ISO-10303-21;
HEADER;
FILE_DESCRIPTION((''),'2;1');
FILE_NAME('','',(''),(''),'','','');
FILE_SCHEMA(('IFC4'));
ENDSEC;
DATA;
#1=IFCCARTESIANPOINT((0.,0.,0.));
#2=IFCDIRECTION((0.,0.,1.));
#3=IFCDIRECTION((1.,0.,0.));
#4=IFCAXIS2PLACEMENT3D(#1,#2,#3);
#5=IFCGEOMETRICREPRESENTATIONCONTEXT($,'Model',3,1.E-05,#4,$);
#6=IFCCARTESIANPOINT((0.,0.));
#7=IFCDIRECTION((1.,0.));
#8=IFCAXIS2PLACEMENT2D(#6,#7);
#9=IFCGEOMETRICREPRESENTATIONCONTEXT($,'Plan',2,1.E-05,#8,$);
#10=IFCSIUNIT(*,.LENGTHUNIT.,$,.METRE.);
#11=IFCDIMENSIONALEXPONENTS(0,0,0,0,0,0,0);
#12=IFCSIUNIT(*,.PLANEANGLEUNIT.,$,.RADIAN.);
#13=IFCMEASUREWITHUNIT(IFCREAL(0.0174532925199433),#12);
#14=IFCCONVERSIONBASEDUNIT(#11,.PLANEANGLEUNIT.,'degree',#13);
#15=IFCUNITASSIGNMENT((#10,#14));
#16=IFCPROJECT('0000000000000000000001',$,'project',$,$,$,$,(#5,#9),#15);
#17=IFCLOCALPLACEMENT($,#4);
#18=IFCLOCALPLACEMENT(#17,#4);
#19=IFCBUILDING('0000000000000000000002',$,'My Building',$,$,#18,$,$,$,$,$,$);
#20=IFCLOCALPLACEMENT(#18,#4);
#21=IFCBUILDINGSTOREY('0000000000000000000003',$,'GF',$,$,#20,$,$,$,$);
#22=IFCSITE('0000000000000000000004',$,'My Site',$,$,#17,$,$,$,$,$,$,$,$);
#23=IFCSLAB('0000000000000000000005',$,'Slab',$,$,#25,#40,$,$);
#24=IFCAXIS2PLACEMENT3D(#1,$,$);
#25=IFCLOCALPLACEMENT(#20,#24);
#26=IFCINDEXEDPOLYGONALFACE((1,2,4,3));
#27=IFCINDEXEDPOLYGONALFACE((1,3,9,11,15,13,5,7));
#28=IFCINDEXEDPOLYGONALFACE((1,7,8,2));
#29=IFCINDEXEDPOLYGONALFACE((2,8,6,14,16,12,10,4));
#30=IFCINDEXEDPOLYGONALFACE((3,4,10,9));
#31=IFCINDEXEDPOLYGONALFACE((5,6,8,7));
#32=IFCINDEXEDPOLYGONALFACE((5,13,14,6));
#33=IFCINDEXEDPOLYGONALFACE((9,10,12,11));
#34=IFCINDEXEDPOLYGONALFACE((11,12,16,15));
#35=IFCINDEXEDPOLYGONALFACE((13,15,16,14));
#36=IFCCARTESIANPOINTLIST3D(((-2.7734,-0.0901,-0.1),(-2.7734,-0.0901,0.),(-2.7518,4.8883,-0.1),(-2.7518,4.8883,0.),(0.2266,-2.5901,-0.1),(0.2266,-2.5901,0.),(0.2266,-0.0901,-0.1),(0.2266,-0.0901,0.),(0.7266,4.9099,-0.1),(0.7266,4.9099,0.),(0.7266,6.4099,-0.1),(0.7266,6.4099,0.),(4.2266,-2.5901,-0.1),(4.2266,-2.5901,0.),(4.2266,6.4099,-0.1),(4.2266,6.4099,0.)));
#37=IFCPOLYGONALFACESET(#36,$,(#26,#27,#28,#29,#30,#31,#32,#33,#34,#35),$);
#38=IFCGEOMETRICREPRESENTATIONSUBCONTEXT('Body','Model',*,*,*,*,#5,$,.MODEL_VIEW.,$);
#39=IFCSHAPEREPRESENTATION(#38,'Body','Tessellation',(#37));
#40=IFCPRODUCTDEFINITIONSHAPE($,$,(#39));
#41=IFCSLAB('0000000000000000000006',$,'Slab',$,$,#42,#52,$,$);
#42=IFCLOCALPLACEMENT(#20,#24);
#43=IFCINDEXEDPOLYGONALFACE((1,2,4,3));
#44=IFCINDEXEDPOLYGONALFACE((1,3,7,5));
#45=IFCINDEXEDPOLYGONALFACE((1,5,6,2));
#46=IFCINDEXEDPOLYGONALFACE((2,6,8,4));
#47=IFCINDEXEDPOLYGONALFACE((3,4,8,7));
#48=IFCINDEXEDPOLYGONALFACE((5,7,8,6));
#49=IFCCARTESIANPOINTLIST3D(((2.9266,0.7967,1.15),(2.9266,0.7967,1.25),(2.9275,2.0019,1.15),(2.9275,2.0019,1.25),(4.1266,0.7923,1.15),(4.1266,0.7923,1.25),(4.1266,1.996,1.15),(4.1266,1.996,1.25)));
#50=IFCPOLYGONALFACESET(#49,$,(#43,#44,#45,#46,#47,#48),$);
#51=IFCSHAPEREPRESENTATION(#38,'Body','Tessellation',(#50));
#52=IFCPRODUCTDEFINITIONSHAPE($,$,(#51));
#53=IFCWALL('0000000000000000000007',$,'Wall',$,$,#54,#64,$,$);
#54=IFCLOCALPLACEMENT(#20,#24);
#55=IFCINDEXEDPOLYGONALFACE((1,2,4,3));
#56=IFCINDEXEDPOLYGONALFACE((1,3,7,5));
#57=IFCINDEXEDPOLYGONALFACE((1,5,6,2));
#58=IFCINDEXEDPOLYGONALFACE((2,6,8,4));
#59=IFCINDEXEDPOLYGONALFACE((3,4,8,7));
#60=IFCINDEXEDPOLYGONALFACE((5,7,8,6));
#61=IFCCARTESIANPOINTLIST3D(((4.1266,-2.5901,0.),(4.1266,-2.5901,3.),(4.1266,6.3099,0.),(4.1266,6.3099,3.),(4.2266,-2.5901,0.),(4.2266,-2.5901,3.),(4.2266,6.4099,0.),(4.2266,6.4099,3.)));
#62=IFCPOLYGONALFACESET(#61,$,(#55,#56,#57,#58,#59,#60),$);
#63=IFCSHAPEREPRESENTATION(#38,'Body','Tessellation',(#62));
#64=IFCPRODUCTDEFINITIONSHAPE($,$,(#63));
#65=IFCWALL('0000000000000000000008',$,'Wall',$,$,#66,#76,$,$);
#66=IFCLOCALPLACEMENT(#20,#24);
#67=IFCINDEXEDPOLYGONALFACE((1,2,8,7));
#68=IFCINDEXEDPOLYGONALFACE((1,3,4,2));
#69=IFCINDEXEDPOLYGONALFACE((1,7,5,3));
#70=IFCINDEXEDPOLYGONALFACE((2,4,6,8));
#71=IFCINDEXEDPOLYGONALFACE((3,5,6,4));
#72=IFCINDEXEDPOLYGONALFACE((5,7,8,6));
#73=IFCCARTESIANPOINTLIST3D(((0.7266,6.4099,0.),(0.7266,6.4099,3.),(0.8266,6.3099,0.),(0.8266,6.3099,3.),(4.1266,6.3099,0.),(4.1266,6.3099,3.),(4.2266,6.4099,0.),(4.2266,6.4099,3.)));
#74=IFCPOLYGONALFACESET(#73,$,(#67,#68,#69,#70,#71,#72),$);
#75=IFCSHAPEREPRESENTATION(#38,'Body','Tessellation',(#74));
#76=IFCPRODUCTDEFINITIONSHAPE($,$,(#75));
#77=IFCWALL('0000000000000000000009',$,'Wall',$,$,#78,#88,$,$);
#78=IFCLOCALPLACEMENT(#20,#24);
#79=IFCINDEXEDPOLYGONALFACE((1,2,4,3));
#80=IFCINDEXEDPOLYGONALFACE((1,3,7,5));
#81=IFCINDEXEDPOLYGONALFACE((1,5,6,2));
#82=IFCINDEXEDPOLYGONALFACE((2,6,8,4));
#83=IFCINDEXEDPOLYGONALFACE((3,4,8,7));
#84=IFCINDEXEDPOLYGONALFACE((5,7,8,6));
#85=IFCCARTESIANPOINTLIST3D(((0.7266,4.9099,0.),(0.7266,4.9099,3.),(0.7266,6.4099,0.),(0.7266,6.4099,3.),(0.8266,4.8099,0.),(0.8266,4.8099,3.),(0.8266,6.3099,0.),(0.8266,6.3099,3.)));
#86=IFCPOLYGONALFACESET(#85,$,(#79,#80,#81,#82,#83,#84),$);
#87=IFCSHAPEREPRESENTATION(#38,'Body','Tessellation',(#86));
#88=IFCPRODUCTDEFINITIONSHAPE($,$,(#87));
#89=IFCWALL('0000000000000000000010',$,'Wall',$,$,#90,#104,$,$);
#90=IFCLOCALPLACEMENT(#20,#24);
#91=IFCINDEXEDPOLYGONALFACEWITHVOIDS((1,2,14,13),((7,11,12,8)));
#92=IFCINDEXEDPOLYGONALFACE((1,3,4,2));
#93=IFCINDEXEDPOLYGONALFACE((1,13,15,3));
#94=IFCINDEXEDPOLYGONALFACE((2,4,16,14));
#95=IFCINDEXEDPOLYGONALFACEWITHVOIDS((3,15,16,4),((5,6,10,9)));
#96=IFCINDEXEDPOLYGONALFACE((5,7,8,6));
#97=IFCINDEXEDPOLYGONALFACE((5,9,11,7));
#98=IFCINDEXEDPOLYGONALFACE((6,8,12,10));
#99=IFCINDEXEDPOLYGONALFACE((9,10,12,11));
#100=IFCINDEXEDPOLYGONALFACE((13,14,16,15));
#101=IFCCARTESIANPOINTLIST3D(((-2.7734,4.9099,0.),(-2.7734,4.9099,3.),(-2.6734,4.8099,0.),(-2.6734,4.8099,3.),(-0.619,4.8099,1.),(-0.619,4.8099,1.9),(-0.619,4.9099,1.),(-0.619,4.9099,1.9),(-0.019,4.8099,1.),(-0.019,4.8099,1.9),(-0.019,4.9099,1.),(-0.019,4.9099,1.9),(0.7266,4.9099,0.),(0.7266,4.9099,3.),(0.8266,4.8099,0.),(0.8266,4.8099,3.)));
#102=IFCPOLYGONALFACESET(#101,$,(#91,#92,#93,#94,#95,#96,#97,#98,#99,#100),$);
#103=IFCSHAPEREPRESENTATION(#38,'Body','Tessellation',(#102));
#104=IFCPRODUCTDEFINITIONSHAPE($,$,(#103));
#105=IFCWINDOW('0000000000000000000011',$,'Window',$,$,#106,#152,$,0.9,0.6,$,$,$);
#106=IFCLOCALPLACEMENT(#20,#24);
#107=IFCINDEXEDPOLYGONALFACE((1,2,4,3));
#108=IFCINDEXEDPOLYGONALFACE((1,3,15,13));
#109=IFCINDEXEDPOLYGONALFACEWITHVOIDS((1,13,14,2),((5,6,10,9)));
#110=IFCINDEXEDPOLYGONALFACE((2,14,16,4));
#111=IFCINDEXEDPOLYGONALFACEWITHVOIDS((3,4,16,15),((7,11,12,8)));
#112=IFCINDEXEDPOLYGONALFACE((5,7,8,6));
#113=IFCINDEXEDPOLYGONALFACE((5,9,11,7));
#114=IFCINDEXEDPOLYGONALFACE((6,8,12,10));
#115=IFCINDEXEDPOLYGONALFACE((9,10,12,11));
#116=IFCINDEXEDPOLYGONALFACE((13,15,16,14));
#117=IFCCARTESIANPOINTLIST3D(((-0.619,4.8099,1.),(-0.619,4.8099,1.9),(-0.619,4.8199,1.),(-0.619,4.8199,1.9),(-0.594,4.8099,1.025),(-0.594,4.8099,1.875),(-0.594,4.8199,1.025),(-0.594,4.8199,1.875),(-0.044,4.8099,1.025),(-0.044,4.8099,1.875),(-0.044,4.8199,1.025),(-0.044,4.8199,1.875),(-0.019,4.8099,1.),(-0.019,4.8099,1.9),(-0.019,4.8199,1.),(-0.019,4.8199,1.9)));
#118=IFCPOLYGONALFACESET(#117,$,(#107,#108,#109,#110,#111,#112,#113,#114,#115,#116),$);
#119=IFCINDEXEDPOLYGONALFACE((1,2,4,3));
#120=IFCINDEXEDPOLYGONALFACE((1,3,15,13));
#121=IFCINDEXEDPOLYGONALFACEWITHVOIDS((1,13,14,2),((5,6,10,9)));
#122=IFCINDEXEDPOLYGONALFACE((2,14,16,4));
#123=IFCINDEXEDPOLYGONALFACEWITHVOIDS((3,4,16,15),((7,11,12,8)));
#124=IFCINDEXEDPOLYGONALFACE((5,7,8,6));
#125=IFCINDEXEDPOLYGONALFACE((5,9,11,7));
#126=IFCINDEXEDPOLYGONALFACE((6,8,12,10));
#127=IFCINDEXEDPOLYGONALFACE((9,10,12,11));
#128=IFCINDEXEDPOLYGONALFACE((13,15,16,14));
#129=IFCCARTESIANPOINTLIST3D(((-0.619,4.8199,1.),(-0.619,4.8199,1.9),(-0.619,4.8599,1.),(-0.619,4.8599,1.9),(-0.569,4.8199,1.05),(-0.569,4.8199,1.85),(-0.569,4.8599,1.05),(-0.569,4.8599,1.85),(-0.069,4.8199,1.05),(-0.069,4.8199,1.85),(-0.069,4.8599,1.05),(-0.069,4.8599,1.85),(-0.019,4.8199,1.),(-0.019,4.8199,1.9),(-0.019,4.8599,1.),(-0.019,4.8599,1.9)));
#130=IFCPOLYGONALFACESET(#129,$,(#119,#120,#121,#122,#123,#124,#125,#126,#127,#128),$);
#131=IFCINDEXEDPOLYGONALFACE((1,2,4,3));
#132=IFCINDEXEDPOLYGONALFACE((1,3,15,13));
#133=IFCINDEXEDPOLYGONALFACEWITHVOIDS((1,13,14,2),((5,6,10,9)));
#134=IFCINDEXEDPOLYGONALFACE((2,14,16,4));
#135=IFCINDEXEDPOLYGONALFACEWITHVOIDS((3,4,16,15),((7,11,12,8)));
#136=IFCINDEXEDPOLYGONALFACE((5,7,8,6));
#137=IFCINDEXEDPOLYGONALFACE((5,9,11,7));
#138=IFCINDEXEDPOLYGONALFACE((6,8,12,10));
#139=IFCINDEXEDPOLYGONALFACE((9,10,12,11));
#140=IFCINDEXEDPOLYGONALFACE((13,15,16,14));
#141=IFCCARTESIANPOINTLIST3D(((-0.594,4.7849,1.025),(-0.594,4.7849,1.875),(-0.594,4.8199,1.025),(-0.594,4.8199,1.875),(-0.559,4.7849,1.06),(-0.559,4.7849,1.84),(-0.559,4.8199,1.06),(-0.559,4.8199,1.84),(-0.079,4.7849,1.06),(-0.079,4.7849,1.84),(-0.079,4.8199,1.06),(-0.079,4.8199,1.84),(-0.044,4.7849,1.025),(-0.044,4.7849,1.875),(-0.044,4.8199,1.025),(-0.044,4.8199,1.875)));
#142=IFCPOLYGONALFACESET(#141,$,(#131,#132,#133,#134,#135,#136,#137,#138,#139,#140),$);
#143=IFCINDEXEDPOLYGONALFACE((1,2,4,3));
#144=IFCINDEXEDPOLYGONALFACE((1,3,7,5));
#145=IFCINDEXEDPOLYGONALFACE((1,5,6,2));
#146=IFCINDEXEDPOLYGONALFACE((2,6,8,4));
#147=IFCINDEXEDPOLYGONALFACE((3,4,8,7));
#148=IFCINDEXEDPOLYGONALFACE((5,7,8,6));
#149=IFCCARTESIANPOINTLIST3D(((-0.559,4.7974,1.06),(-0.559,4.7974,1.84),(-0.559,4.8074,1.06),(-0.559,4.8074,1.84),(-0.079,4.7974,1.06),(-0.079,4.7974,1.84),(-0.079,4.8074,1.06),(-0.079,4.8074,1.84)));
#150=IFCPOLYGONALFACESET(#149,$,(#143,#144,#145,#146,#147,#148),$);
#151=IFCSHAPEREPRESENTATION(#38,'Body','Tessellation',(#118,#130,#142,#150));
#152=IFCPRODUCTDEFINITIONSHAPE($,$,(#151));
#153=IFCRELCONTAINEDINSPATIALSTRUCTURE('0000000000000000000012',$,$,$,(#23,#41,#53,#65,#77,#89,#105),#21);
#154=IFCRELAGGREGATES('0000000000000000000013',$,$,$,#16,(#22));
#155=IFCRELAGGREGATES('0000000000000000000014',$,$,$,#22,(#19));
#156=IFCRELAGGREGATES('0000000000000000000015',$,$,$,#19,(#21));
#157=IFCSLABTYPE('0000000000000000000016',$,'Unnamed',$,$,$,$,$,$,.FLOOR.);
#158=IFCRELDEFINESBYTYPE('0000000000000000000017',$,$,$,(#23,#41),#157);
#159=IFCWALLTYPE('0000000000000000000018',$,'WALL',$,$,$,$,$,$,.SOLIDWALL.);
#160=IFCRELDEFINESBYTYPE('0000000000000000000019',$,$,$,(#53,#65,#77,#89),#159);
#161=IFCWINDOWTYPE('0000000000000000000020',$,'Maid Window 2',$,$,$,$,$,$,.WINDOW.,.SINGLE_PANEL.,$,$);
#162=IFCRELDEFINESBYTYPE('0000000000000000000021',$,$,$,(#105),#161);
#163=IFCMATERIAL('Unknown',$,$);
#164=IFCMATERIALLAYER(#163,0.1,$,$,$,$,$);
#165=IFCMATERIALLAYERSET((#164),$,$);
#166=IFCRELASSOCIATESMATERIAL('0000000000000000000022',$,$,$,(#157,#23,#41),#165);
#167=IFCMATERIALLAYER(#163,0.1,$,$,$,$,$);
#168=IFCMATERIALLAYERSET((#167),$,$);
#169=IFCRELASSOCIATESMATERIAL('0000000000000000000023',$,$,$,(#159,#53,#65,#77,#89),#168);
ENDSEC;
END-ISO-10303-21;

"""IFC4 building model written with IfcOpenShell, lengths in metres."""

from ifc_helpers import new_model, entity, si_unit, converted_unit, frame, origin_with_axes, origin_2d_with_axis, place, context, subcontext, project, spatial, line, indexed_curve, outline, extrude, shape, source, transform, mapped, material, layer, layer_set, layer_usage, type_object, type_shapes, element, fill, save


model = new_model("IFC4")

# Units and contexts
model_context = context("Model", 3, precision=1e-05, world=origin_with_axes())
plan_context = context("Plan", 2, precision=1e-05, world=origin_2d_with_axis())
body_context_1 = subcontext(model_context, "Body", "Model", "MODEL_VIEW")
body_context_2 = subcontext(plan_context, "Body", "Plan", "PLAN_VIEW")
ifc_project = project(units=[si_unit("LENGTHUNIT", "METRE"), converted_unit("PLANEANGLEUNIT", "degree", entity("IfcReal", 0.0174532925199433), si_unit("PLANEANGLEUNIT", "RADIAN"), dimensions=[0, 0, 0, 0, 0, 0, 0])], contexts=[model_context, plan_context])

# Site, building, storey
site_placement = place(None, origin_with_axes())
site = spatial("IfcSite", under=ifc_project, at=site_placement, Name="My Site")
building_placement = place(site_placement, origin_with_axes())
building = spatial("IfcBuilding", under=site, at=building_placement, Name="My Building")
storey_placement = place(building_placement, origin_with_axes())
storey = spatial("IfcBuildingStorey", under=building, at=storey_placement, Name="GF")

# Slabs
ifc_material_1 = material(Name="Unknown")
ifc_layer_1 = layer(ifc_material_1, 0.1)
ifc_layer_set_1 = layer_set([ifc_layer_1])
ifc_layer_usage_1 = layer_usage(ifc_layer_set_1, "AXIS3", "POSITIVE", -0.1)
slab_type = type_object("IfcSlabType", Name="Unnamed", PredefinedType="FLOOR", material=ifc_layer_set_1)
slab_1_placement = place(storey_placement, frame((0.7266, 6.4099, 0.0), z_axis=(0.0, 0.0, 1.0), x_axis=(1.0, 0.0, 0.0)))
element("IfcSlab", 1, at=slab_1_placement, inside=storey, type_object=slab_type, material=ifc_layer_usage_1, Name="Slab", context=body_context_1, shape_type="SweptSolid", body=[
    extrude(outline(indexed_curve([(0.0, 0.0), (3.5, 0.0), (3.5, -9.0), (-0.5, -9.0), (-0.5, -6.5), (-3.5, -6.5), (-3.4784, -1.5216), (0.0, -1.5), (0.0, 0.0)])), frame((0.0, 0.0, -0.1), z_axis=(0.0, 0.0, 1.0), x_axis=(1.0, 0.0, 0.0)), (0.0, 0.0, 1.0), 0.1),
])
ifc_layer_usage_2 = layer_usage(ifc_layer_set_1, "AXIS3", "POSITIVE", -0.1)
slab_2_placement = place(storey_placement, frame((2.9266, 0.7967, 1.25), z_axis=(0.0, 0.0, 1.0), x_axis=(1.0, 0.0, 0.0)))
element("IfcSlab", 2, at=slab_2_placement, inside=storey, type_object=slab_type, material=ifc_layer_usage_2, Name="Slab", context=body_context_1, shape_type="SweptSolid", body=[
    extrude(outline(indexed_curve([(0.0, 0.0), (1.2, -0.0044), (1.2, 1.1993), (0.0009, 1.2051), (0.0, 0.0)])), frame((0.0, 0.0, -0.1), z_axis=(0.0, 0.0, 1.0), x_axis=(1.0, 0.0, 0.0)), (0.0, 0.0, 1.0), 0.1),
])

# Walls
ifc_layer_2 = layer(ifc_material_1, 0.1)
ifc_layer_set_2 = layer_set([ifc_layer_2])
ifc_layer_usage_3 = layer_usage(ifc_layer_set_2, "AXIS2", "POSITIVE", 0.0)
wall_type = type_object("IfcWallType", Name="WALL", PredefinedType="SOLIDWALL", material=ifc_layer_set_2)
wall_1_placement = place(storey_placement, frame((4.2266, -2.5901, 0.0), z_axis=(0.0, 0.0, 1.0), x_axis=(0.0, 1.0, 0.0)))
element("IfcWall", 3, at=wall_1_placement, inside=storey, type_object=wall_type, material=ifc_layer_usage_3, Name="Wall", context=body_context_1, shape_type="SweptSolid", body=[
    extrude(outline(indexed_curve([(0.0, 0.0), (0.0, 0.1), (8.9, 0.1), (9.0, 0.0)], segments=[line(1, 2, 3, 4, 1)])), origin_with_axes(), (0.0, 0.0, 1.0), 3.0),
])
ifc_layer_usage_4 = layer_usage(ifc_layer_set_2, "AXIS2", "POSITIVE", 0.0)
wall_2_placement = place(storey_placement, frame((4.2266, 6.4099, 0.0), z_axis=(0.0, 0.0, 1.0), x_axis=(-1.0, 0.0, 0.0)))
element("IfcWall", 4, at=wall_2_placement, inside=storey, type_object=wall_type, material=ifc_layer_usage_4, Name="Wall", context=body_context_1, shape_type="SweptSolid", body=[
    extrude(outline(indexed_curve([(0.0, 0.0), (0.1, 0.1), (3.4, 0.1), (3.5, 0.0)], segments=[line(1, 2, 3, 4, 1)])), origin_with_axes(), (0.0, 0.0, 1.0), 3.0),
])
ifc_layer_usage_5 = layer_usage(ifc_layer_set_2, "AXIS2", "POSITIVE", 0.0)
wall_3_placement = place(storey_placement, frame((0.7266, 6.4099, 0.0), z_axis=(0.0, 0.0, 1.0), x_axis=(0.0, -1.0, 0.0)))
element("IfcWall", 5, at=wall_3_placement, inside=storey, type_object=wall_type, material=ifc_layer_usage_5, Name="Wall", context=body_context_1, shape_type="SweptSolid", body=[
    extrude(outline(indexed_curve([(0.0, 0.0), (0.1, 0.1), (1.6, 0.1), (1.5, 0.0)], segments=[line(1, 2, 3, 4, 1)])), origin_with_axes(), (0.0, 0.0, 1.0), 3.0),
])

# Wall, opening, window
ifc_layer_usage_6 = layer_usage(ifc_layer_set_2, "AXIS2", "POSITIVE", 0.0)
wall_4_placement = place(storey_placement, frame((0.7266, 4.9099, 0.0), z_axis=(0.0, 0.0, 1.0), x_axis=(-1.0, 0.0, 0.0)))
wall_4 = element("IfcWall", 6, at=wall_4_placement, inside=storey, type_object=wall_type, material=ifc_layer_usage_6, Name="Wall", context=body_context_1, shape_type="SweptSolid", body=[
    extrude(outline(indexed_curve([(0.0, 0.0), (-0.1, 0.1), (3.4, 0.1), (3.5, 0.0)], segments=[line(1, 2, 3, 4, 1)])), origin_with_axes(), (0.0, 0.0, 1.0), 3.0),
])
shared_shape_1 = source(origin_with_axes(), body_context_1, "Body", "SweptSolid", [
    extrude(outline(indexed_curve([(0.0, 0.0), (0.6, 0.0), (0.6, 0.9), (0.0, 0.9)], segments=[line(1, 2, 3, 4, 1)])), frame((0.0, -0.6, 0.0), z_axis=(0.0, -1.0, 0.0), x_axis=(1.0, 0.0, 0.0)), (0.0, 0.0, -1.0), 1.2),
])
opening_1_placement = place(wall_4_placement, frame((0.7456, 0.0, 1.0), z_axis=(0.0, 0.0, 1.0), x_axis=(1.0, 0.0, 0.0)))
opening_1 = element("IfcOpeningElement", 7, at=opening_1_placement, cuts=wall_4, PredefinedType="OPENING", context=body_context_1, shape_type="MappedRepresentation", body=[
    mapped(shared_shape_1, transform((0.0, 0.0, 0.0), x_axis=(1.0, 0.0, 0.0), y_axis=(0.0, 1.0, 0.0), z_axis=(0.0, 0.0, 1.0), scale=1.0)),
])
window_type_1 = type_object("IfcWindowType", Name="Maid Window 2", PartitioningType="SINGLE_PANEL", PredefinedType="WINDOW")
shared_shape_2 = source(origin_with_axes(), body_context_1, "Body", "SweptSolid", [
    extrude(outline(indexed_curve([(0.0, 0.0), (0.6, 0.0), (0.6, 0.9), (0.0, 0.9)], segments=[line(1, 2, 3, 4, 1)]), holes=[indexed_curve([(0.025, 0.025), (0.575, 0.025), (0.575, 0.875), (0.025, 0.875)], segments=[line(1, 2, 3, 4, 1)])]), frame((0.0, 0.09, 0.0), z_axis=(0.0, -1.0, 0.0), x_axis=(1.0, 0.0, 0.0)), (0.0, 0.0, -1.0), 0.01),
    extrude(outline(indexed_curve([(0.0, 0.0), (0.6, 0.0), (0.6, 0.9), (0.0, 0.9)], segments=[line(1, 2, 3, 4, 1)]), holes=[indexed_curve([(0.05, 0.05), (0.55, 0.05), (0.55, 0.85), (0.05, 0.85)], segments=[line(1, 2, 3, 4, 1)])]), frame((0.0, 0.05, 0.0), z_axis=(0.0, -1.0, 0.0), x_axis=(1.0, 0.0, 0.0)), (0.0, 0.0, -1.0), 0.04),
    extrude(outline(indexed_curve([(0.0, 0.0), (0.55, 0.0), (0.55, 0.85), (0.0, 0.85)], segments=[line(1, 2, 3, 4, 1)]), holes=[indexed_curve([(0.035, 0.035), (0.515, 0.035), (0.515, 0.815), (0.035, 0.815)], segments=[line(1, 2, 3, 4, 1)])]), frame((0.025, 0.09, 0.025), z_axis=(0.0, -1.0, 0.0), x_axis=(1.0, 0.0, 0.0)), (0.0, 0.0, -1.0), 0.035),
    extrude(outline(indexed_curve([(0.035, 0.035), (0.515, 0.035), (0.515, 0.815), (0.035, 0.815)], segments=[line(1, 2, 3, 4, 1)])), frame((0.025, 0.1025, 0.025), z_axis=(0.0, -1.0, 0.0), x_axis=(1.0, 0.0, 0.0)), (0.0, 0.0, -1.0), 0.01),
])
shared_shape_3 = source(origin_with_axes(), body_context_2, "Body", "Curve2D", [
    entity("IfcIndexedPolyCurve", entity("IfcCartesianPointList2D", [[0.05, 0.05], [0.55, 0.05]])),
    entity("IfcIndexedPolyCurve", entity("IfcCartesianPointList2D", [[0.0, 0.1], [0.025, 0.1], [0.025, 0.09], [0.05, 0.09], [0.05, 0.05], [0.0, 0.05]]), [entity("IfcLineIndex", [1, 2, 3, 4, 5, 6, 1])]),
    entity("IfcIndexedPolyCurve", entity("IfcCartesianPointList2D", [[0.6, 0.1], [0.575, 0.1], [0.575, 0.09], [0.55, 0.09], [0.55, 0.05], [0.6, 0.05]]), [entity("IfcLineIndex", [1, 2, 3, 4, 5, 6, 1])]),
    entity("IfcIndexedPolyCurve", entity("IfcCartesianPointList2D", [[0.025, 0.09], [0.06, 0.09], [0.06, 0.125], [0.025, 0.125]]), [entity("IfcLineIndex", [1, 2, 3, 4, 1])]),
    entity("IfcIndexedPolyCurve", entity("IfcCartesianPointList2D", [[0.575, 0.09], [0.54, 0.09], [0.54, 0.125], [0.575, 0.125]]), [entity("IfcLineIndex", [1, 2, 3, 4, 1])]),
    entity("IfcIndexedPolyCurve", entity("IfcCartesianPointList2D", [[0.06, 0.09], [0.54, 0.09]])),
    entity("IfcIndexedPolyCurve", entity("IfcCartesianPointList2D", [[0.06, 0.125], [0.54, 0.125]])),
    entity("IfcIndexedPolyCurve", entity("IfcCartesianPointList2D", [[0.06, 0.1075], [0.54, 0.1075]])),
])
type_shapes(window_type_1, [shared_shape_2, shared_shape_3])
window_1_placement = place(opening_1_placement, frame((0.0, 0.0, 0.0), z_axis=(0.0, 0.0, 1.0), x_axis=(1.0, 0.0, 0.0)))
window_1 = element("IfcWindow", 8, at=window_1_placement, inside=storey, type_object=window_type_1, Name="Window", OverallHeight=0.9, OverallWidth=0.6, shapes=[
    shape(body_context_1, "Body", "MappedRepresentation", [mapped(shared_shape_2, transform((0.0, 0.0, 0.0), x_axis=(1.0, 0.0, 0.0), y_axis=(0.0, 1.0, 0.0), z_axis=(0.0, 0.0, 1.0), scale=1.0))]),
    shape(body_context_2, "Body", "MappedRepresentation", [mapped(shared_shape_3, transform((0.0, 0.0, 0.0), x_axis=(1.0, 0.0, 0.0), y_axis=(0.0, 1.0, 0.0), z_axis=(0.0, 0.0, 1.0), scale=1.0))]),
])
fill(opening_1, window_1)

save(model, "model.ifc")
